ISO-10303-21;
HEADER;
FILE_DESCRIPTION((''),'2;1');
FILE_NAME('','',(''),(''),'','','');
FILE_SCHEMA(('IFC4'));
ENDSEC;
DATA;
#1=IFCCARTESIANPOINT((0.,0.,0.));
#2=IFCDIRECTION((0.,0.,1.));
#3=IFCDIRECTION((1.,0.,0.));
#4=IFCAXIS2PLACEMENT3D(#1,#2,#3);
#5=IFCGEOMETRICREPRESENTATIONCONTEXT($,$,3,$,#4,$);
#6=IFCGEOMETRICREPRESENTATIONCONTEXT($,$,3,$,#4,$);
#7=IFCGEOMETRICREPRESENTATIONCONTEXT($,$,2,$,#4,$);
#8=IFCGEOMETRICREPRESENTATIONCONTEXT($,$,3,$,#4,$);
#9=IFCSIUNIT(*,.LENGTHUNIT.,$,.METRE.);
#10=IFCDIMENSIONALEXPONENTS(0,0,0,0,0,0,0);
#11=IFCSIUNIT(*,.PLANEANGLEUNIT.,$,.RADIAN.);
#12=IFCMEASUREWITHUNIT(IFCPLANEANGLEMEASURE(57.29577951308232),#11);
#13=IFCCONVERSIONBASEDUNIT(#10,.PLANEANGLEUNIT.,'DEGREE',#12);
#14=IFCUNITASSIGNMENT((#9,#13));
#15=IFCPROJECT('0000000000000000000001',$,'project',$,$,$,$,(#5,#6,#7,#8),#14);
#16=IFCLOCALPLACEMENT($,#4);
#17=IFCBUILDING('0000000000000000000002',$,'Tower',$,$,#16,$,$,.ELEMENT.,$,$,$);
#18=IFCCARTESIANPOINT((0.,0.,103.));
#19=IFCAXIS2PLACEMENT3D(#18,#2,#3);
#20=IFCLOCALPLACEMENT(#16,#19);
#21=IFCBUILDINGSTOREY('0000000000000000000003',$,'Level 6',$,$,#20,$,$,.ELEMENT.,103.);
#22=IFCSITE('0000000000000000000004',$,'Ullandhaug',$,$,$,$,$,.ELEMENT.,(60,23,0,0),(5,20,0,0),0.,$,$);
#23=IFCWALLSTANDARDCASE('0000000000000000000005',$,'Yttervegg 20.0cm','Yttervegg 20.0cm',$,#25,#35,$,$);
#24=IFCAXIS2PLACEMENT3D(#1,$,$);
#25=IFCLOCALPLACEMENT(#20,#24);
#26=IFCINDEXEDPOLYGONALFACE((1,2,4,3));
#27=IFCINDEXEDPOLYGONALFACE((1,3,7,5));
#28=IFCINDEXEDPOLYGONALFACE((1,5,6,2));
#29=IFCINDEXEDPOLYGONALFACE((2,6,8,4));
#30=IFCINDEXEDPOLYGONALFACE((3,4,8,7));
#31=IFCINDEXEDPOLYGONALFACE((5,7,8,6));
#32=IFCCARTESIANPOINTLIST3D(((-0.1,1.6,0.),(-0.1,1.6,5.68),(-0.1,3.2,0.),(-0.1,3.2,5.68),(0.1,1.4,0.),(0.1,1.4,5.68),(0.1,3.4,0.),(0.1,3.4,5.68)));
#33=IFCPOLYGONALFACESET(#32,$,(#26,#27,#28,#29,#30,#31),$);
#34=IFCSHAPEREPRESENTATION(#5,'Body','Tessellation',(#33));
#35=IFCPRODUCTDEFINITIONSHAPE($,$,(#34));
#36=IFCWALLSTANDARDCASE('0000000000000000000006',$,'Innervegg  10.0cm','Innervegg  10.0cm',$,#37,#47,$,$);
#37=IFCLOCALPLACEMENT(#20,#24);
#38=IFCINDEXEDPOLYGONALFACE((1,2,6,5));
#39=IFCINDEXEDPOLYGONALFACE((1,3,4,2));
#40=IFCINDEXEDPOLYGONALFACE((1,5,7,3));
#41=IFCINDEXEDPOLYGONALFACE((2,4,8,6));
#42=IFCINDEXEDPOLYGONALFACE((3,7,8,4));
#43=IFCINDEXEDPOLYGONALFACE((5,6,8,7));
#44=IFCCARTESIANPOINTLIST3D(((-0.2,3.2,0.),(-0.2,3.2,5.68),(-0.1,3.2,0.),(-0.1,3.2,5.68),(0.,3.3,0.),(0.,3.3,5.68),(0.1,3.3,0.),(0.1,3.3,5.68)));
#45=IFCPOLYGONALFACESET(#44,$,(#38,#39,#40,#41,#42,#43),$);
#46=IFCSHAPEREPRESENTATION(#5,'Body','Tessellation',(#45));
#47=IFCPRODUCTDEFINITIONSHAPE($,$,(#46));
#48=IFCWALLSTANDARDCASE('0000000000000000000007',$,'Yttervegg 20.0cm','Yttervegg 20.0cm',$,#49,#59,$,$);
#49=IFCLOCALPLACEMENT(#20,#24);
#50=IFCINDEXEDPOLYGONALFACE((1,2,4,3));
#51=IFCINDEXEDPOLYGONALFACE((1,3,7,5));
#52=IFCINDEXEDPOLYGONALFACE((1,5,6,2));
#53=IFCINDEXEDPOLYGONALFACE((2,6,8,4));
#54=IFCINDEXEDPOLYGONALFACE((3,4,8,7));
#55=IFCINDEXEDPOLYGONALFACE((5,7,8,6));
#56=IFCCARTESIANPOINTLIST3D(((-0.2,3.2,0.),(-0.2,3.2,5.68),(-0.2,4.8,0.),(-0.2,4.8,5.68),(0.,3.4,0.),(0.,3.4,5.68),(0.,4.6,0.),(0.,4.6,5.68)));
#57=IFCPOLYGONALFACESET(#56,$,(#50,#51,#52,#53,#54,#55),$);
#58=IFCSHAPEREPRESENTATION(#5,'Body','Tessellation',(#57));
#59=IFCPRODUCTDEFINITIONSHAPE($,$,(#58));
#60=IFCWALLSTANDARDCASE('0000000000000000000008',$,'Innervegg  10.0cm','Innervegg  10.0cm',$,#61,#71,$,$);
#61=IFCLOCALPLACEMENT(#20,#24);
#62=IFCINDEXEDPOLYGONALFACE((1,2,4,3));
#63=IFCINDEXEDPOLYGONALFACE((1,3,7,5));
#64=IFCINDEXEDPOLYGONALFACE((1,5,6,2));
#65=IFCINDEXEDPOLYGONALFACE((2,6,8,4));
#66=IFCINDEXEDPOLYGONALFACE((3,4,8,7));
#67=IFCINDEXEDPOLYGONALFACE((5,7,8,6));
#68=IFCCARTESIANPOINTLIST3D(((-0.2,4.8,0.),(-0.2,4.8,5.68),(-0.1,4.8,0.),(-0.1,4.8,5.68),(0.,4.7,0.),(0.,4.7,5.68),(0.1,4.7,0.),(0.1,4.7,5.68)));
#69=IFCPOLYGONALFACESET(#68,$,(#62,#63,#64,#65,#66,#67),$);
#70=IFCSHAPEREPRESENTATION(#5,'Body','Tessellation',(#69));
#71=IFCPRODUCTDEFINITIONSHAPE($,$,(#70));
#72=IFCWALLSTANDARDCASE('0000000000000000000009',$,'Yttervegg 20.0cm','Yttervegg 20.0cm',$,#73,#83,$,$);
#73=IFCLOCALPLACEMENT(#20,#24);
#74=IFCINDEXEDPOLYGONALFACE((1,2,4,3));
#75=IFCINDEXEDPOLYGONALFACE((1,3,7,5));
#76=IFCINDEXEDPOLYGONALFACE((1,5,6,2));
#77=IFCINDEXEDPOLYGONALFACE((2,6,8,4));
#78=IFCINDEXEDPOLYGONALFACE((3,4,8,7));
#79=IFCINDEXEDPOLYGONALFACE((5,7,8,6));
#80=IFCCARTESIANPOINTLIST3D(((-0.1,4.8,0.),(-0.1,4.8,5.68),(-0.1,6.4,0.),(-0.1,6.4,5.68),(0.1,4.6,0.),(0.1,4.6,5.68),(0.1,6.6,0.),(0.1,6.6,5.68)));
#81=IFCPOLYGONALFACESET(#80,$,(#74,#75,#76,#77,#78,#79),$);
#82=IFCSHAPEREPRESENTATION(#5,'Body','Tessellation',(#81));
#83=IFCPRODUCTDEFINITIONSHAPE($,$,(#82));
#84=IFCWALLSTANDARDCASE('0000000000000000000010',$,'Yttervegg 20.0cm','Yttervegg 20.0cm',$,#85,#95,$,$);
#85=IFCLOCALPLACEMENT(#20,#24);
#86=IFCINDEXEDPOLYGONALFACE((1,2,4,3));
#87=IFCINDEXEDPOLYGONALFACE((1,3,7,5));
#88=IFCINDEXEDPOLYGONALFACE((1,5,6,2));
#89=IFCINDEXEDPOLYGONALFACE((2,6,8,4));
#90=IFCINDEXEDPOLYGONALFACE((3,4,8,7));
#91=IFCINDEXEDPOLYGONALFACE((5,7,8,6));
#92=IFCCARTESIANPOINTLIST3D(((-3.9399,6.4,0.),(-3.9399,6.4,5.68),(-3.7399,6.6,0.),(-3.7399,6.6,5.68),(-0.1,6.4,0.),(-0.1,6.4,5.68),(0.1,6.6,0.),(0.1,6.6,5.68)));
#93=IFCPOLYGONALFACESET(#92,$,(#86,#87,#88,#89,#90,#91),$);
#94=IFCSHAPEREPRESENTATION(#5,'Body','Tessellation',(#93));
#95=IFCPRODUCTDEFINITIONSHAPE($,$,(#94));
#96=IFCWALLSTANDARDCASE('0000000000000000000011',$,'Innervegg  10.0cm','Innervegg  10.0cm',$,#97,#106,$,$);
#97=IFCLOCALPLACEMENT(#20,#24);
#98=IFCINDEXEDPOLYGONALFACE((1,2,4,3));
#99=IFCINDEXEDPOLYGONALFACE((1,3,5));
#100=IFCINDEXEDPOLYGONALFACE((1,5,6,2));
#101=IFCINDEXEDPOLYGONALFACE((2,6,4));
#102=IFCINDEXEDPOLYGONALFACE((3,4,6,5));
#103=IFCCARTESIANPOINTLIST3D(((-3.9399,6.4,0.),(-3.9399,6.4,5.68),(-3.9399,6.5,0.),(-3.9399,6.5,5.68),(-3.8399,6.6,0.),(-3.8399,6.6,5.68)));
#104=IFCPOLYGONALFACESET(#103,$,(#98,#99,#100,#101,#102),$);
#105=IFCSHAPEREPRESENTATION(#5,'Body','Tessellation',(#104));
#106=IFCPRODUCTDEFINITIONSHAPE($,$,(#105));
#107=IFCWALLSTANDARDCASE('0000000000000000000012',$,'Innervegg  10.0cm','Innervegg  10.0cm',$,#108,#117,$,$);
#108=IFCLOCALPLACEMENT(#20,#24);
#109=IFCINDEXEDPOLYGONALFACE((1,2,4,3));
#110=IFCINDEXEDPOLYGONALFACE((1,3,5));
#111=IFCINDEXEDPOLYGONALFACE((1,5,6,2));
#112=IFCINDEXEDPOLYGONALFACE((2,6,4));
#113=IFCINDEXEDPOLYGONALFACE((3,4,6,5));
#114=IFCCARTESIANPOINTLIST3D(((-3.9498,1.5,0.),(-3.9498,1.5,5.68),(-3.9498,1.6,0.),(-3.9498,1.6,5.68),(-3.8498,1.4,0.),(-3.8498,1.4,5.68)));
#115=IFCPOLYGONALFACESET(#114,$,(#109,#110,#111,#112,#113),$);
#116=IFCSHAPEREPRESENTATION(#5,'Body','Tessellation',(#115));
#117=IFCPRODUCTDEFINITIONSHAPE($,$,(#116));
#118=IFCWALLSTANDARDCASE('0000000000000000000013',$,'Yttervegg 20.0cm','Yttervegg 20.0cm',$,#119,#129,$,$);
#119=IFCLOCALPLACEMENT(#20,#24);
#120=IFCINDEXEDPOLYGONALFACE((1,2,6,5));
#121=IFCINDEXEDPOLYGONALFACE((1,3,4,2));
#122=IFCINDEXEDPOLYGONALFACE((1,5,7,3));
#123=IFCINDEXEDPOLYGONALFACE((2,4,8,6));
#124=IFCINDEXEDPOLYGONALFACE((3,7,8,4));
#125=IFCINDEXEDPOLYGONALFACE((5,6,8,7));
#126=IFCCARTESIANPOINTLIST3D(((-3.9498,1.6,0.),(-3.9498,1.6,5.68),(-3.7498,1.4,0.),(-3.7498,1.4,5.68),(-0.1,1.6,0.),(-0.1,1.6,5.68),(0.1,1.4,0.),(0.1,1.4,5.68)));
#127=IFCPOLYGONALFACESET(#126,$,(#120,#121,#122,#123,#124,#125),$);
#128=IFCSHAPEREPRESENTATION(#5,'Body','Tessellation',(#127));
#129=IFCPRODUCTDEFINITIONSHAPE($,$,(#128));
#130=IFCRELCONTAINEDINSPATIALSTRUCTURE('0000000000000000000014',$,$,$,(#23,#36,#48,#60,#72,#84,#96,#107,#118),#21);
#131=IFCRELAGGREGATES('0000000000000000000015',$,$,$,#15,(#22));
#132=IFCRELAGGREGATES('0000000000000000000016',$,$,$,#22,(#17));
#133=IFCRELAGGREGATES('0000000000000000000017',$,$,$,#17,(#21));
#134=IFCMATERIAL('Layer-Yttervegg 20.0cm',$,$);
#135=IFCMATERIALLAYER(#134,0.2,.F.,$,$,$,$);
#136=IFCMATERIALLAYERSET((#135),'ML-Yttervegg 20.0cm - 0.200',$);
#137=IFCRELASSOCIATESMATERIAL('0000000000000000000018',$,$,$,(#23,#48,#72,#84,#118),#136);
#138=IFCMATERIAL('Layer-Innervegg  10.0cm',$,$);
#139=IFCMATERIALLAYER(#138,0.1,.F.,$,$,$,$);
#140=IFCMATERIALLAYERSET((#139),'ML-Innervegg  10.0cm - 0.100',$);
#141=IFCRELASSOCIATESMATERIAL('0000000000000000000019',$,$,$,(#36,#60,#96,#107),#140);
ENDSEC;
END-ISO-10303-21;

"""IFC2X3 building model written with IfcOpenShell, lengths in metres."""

from ifc_helpers import new_model, entity, si_unit, converted_unit, frame, origin_with_axes, place, context, project, spatial, polyline, outline, extrude, material, layer, layer_set, layer_usage, element, save


model = new_model("IFC2X3")

# Units and contexts
context_of_model_1 = context(None, 3, world=origin_with_axes())
context_of_model_2 = context(None, 3, world=origin_with_axes())
context_of_model_3 = context(None, 2, world=origin_with_axes())
context_of_model_4 = context(None, 3, world=origin_with_axes())
ifc_project = project(units=[si_unit("LENGTHUNIT", "METRE"), converted_unit("PLANEANGLEUNIT", "DEGREE", entity("IfcPlaneAngleMeasure", 57.29577951308232), si_unit("PLANEANGLEUNIT", "RADIAN"), dimensions=[0, 0, 0, 0, 0, 0, 0])], contexts=[context_of_model_1, context_of_model_2, context_of_model_3, context_of_model_4])

# Site, building, storey
site = spatial("IfcSite", under=ifc_project, Name="Ullandhaug", CompositionType="ELEMENT", RefLatitude=(60, 23, 0, 0), RefLongitude=(5, 20, 0, 0), RefElevation=0.0)
building_placement = place(None, origin_with_axes())
building = spatial("IfcBuilding", under=site, at=building_placement, Name="Tower", CompositionType="ELEMENT")
storey_placement = place(building_placement, frame((0.0, 0.0, 103.0), z_axis=(0.0, 0.0, 1.0), x_axis=(1.0, 0.0, 0.0)))
storey = spatial("IfcBuildingStorey", under=building, at=storey_placement, Name="Level 6", CompositionType="ELEMENT", Elevation=103.0)

# Shared definitions
ifc_material_1 = material(Name="Layer-Yttervegg 20.0cm")
ifc_layer_1 = layer(ifc_material_1, 0.2, ventilated=False)
ifc_layer_set_1 = layer_set([ifc_layer_1], Name="ML-Yttervegg 20.0cm - 0.200")
ifc_layer_usage_1 = layer_usage(ifc_layer_set_1, "AXIS2", "POSITIVE", 0.0)

# Walls
wall_1_placement = place(storey_placement, frame((0.1, 1.4, 0.0), z_axis=(0.0, 0.0, 1.0), x_axis=(0.0, 1.0, 0.0)))
element("IfcWallStandardCase", 1, at=wall_1_placement, inside=storey, material=ifc_layer_usage_1, Name="Yttervegg 20.0cm", Description="Yttervegg 20.0cm", context=context_of_model_1, shape_type="SweptSolid", body=[
    extrude(outline(polyline([(0.0, 0.0), (2.0, 0.0), (1.8, 0.2), (0.2, 0.2), (0.0, 0.0)])), frame((0.0, 0.0, 0.0), z_axis=(0.0, 0.0, 1.0), x_axis=(1.0, 0.0, 0.0)), (0.0, 0.0, 1.0), 5.68),
])
ifc_material_2 = material(Name="Layer-Innervegg  10.0cm")
ifc_layer_2 = layer(ifc_material_2, 0.1, ventilated=False)
ifc_layer_set_2 = layer_set([ifc_layer_2], Name="ML-Innervegg  10.0cm - 0.100")
ifc_layer_usage_2 = layer_usage(ifc_layer_set_2, "AXIS2", "POSITIVE", 0.0)
wall_2_placement = place(storey_placement, frame((0.1, 3.3, 0.0), z_axis=(0.0, 0.0, 1.0), x_axis=(-1.0, 0.0, 0.0)))
element("IfcWallStandardCase", 2, at=wall_2_placement, inside=storey, material=ifc_layer_usage_2, Name="Innervegg  10.0cm", Description="Innervegg  10.0cm", context=context_of_model_1, shape_type="SweptSolid", body=[
    extrude(outline(polyline([(0.0, 0.0), (0.1, 0.0), (0.3, 0.1), (0.2, 0.1), (0.0, 0.0)])), frame((0.0, 0.0, 0.0), z_axis=(0.0, 0.0, 1.0), x_axis=(1.0, 0.0, 0.0)), (0.0, 0.0, 1.0), 5.68),
])
wall_3_placement = place(storey_placement, frame((0.0, 3.4, 0.0), z_axis=(0.0, 0.0, 1.0), x_axis=(0.0, 1.0, 0.0)))
element("IfcWallStandardCase", 3, at=wall_3_placement, inside=storey, material=ifc_layer_usage_1, Name="Yttervegg 20.0cm", Description="Yttervegg 20.0cm", context=context_of_model_1, shape_type="SweptSolid", body=[
    extrude(outline(polyline([(0.0, 0.0), (1.2, 0.0), (1.4, 0.2), (-0.2, 0.2), (0.0, 0.0)])), frame((0.0, 0.0, 0.0), z_axis=(0.0, 0.0, 1.0), x_axis=(1.0, 0.0, 0.0)), (0.0, 0.0, 1.0), 5.68),
])
wall_4_placement = place(storey_placement, frame((0.0, 4.7, 0.0), z_axis=(0.0, 0.0, 1.0), x_axis=(1.0, 0.0, 0.0)))
element("IfcWallStandardCase", 4, at=wall_4_placement, inside=storey, material=ifc_layer_usage_2, Name="Innervegg  10.0cm", Description="Innervegg  10.0cm", context=context_of_model_1, shape_type="SweptSolid", body=[
    extrude(outline(polyline([(0.0, 0.0), (0.1, 0.0), (-0.1, 0.1), (-0.2, 0.1), (0.0, 0.0)])), origin_with_axes(), (0.0, 0.0, 1.0), 5.68),
])
wall_5_placement = place(storey_placement, frame((0.1, 4.6, 0.0), z_axis=(0.0, 0.0, 1.0), x_axis=(0.0, 1.0, 0.0)))
element("IfcWallStandardCase", 5, at=wall_5_placement, inside=storey, material=ifc_layer_usage_1, Name="Yttervegg 20.0cm", Description="Yttervegg 20.0cm", context=context_of_model_1, shape_type="SweptSolid", body=[
    extrude(outline(polyline([(0.0, 0.0), (2.0, 0.0), (1.8, 0.2), (0.2, 0.2), (0.0, 0.0)])), frame((0.0, 0.0, 0.0), z_axis=(0.0, 0.0, 1.0), x_axis=(1.0, 0.0, 0.0)), (0.0, 0.0, 1.0), 5.68),
])
wall_6_placement = place(storey_placement, frame((0.1, 6.6, 0.0), z_axis=(0.0, 0.0, 1.0), x_axis=(-1.0, 0.0, 0.0)))
element("IfcWallStandardCase", 6, at=wall_6_placement, inside=storey, material=ifc_layer_usage_1, Name="Yttervegg 20.0cm", Description="Yttervegg 20.0cm", context=context_of_model_1, shape_type="SweptSolid", body=[
    extrude(outline(polyline([(0.0, 0.0), (3.8399, 0.0), (4.0399, 0.2), (0.2, 0.2), (0.0, 0.0)])), frame((0.0, 0.0, 0.0), z_axis=(0.0, 0.0, 1.0), x_axis=(1.0, 0.0, 0.0)), (0.0, 0.0, 1.0), 5.68),
])
wall_7_placement = place(storey_placement, frame((-3.8399, 6.6, 0.0), z_axis=(0.0, 0.0, 1.0), x_axis=(0.0, 1.0, 0.0)))
element("IfcWallStandardCase", 7, at=wall_7_placement, inside=storey, material=ifc_layer_usage_2, Name="Innervegg  10.0cm", Description="Innervegg  10.0cm", context=context_of_model_1, shape_type="SweptSolid", body=[
    extrude(outline(polyline([(0.0, 0.0), (0.0, 0.0), (0.1414, 0.0), (0.2121, 0.0707), (0.0, 0.0)])), frame((0.0, 0.0, 0.0), z_axis=(0.0, 0.0, 1.0), x_axis=(-0.707105, 0.707108, 0.0)), (0.0, 0.0, 1.0), 5.68),
])
wall_8_placement = place(storey_placement, frame((-3.8498, 1.4, 0.0), z_axis=(0.0, 0.0, 1.0), x_axis=(1.0, 0.0, 0.0)))
element("IfcWallStandardCase", 8, at=wall_8_placement, inside=storey, material=ifc_layer_usage_2, Name="Innervegg  10.0cm", Description="Innervegg  10.0cm", context=context_of_model_1, shape_type="SweptSolid", body=[
    extrude(outline(polyline([(0.0, 0.0), (0.0, 0.0), (0.2236, 0.0), (0.1342, 0.0447), (0.0, 0.0)])), frame((0.0, 0.0, 0.0), z_axis=(0.0, 0.0, 1.0), x_axis=(-0.447213, 0.894427, 0.0)), (0.0, 0.0, 1.0), 5.68),
])
wall_9_placement = place(storey_placement, frame((-3.7498, 1.4, 0.0), z_axis=(0.0, 0.0, 1.0), x_axis=(1.0, 0.0, 0.0)))
element("IfcWallStandardCase", 9, at=wall_9_placement, inside=storey, material=ifc_layer_usage_1, Name="Yttervegg 20.0cm", Description="Yttervegg 20.0cm", context=context_of_model_1, shape_type="SweptSolid", body=[
    extrude(outline(polyline([(0.0, 0.0), (3.8498, 0.0), (3.6498, 0.2), (-0.2, 0.2), (0.0, 0.0)])), origin_with_axes(), (0.0, 0.0, 1.0), 5.68),
])

save(model, "model.ifc")
